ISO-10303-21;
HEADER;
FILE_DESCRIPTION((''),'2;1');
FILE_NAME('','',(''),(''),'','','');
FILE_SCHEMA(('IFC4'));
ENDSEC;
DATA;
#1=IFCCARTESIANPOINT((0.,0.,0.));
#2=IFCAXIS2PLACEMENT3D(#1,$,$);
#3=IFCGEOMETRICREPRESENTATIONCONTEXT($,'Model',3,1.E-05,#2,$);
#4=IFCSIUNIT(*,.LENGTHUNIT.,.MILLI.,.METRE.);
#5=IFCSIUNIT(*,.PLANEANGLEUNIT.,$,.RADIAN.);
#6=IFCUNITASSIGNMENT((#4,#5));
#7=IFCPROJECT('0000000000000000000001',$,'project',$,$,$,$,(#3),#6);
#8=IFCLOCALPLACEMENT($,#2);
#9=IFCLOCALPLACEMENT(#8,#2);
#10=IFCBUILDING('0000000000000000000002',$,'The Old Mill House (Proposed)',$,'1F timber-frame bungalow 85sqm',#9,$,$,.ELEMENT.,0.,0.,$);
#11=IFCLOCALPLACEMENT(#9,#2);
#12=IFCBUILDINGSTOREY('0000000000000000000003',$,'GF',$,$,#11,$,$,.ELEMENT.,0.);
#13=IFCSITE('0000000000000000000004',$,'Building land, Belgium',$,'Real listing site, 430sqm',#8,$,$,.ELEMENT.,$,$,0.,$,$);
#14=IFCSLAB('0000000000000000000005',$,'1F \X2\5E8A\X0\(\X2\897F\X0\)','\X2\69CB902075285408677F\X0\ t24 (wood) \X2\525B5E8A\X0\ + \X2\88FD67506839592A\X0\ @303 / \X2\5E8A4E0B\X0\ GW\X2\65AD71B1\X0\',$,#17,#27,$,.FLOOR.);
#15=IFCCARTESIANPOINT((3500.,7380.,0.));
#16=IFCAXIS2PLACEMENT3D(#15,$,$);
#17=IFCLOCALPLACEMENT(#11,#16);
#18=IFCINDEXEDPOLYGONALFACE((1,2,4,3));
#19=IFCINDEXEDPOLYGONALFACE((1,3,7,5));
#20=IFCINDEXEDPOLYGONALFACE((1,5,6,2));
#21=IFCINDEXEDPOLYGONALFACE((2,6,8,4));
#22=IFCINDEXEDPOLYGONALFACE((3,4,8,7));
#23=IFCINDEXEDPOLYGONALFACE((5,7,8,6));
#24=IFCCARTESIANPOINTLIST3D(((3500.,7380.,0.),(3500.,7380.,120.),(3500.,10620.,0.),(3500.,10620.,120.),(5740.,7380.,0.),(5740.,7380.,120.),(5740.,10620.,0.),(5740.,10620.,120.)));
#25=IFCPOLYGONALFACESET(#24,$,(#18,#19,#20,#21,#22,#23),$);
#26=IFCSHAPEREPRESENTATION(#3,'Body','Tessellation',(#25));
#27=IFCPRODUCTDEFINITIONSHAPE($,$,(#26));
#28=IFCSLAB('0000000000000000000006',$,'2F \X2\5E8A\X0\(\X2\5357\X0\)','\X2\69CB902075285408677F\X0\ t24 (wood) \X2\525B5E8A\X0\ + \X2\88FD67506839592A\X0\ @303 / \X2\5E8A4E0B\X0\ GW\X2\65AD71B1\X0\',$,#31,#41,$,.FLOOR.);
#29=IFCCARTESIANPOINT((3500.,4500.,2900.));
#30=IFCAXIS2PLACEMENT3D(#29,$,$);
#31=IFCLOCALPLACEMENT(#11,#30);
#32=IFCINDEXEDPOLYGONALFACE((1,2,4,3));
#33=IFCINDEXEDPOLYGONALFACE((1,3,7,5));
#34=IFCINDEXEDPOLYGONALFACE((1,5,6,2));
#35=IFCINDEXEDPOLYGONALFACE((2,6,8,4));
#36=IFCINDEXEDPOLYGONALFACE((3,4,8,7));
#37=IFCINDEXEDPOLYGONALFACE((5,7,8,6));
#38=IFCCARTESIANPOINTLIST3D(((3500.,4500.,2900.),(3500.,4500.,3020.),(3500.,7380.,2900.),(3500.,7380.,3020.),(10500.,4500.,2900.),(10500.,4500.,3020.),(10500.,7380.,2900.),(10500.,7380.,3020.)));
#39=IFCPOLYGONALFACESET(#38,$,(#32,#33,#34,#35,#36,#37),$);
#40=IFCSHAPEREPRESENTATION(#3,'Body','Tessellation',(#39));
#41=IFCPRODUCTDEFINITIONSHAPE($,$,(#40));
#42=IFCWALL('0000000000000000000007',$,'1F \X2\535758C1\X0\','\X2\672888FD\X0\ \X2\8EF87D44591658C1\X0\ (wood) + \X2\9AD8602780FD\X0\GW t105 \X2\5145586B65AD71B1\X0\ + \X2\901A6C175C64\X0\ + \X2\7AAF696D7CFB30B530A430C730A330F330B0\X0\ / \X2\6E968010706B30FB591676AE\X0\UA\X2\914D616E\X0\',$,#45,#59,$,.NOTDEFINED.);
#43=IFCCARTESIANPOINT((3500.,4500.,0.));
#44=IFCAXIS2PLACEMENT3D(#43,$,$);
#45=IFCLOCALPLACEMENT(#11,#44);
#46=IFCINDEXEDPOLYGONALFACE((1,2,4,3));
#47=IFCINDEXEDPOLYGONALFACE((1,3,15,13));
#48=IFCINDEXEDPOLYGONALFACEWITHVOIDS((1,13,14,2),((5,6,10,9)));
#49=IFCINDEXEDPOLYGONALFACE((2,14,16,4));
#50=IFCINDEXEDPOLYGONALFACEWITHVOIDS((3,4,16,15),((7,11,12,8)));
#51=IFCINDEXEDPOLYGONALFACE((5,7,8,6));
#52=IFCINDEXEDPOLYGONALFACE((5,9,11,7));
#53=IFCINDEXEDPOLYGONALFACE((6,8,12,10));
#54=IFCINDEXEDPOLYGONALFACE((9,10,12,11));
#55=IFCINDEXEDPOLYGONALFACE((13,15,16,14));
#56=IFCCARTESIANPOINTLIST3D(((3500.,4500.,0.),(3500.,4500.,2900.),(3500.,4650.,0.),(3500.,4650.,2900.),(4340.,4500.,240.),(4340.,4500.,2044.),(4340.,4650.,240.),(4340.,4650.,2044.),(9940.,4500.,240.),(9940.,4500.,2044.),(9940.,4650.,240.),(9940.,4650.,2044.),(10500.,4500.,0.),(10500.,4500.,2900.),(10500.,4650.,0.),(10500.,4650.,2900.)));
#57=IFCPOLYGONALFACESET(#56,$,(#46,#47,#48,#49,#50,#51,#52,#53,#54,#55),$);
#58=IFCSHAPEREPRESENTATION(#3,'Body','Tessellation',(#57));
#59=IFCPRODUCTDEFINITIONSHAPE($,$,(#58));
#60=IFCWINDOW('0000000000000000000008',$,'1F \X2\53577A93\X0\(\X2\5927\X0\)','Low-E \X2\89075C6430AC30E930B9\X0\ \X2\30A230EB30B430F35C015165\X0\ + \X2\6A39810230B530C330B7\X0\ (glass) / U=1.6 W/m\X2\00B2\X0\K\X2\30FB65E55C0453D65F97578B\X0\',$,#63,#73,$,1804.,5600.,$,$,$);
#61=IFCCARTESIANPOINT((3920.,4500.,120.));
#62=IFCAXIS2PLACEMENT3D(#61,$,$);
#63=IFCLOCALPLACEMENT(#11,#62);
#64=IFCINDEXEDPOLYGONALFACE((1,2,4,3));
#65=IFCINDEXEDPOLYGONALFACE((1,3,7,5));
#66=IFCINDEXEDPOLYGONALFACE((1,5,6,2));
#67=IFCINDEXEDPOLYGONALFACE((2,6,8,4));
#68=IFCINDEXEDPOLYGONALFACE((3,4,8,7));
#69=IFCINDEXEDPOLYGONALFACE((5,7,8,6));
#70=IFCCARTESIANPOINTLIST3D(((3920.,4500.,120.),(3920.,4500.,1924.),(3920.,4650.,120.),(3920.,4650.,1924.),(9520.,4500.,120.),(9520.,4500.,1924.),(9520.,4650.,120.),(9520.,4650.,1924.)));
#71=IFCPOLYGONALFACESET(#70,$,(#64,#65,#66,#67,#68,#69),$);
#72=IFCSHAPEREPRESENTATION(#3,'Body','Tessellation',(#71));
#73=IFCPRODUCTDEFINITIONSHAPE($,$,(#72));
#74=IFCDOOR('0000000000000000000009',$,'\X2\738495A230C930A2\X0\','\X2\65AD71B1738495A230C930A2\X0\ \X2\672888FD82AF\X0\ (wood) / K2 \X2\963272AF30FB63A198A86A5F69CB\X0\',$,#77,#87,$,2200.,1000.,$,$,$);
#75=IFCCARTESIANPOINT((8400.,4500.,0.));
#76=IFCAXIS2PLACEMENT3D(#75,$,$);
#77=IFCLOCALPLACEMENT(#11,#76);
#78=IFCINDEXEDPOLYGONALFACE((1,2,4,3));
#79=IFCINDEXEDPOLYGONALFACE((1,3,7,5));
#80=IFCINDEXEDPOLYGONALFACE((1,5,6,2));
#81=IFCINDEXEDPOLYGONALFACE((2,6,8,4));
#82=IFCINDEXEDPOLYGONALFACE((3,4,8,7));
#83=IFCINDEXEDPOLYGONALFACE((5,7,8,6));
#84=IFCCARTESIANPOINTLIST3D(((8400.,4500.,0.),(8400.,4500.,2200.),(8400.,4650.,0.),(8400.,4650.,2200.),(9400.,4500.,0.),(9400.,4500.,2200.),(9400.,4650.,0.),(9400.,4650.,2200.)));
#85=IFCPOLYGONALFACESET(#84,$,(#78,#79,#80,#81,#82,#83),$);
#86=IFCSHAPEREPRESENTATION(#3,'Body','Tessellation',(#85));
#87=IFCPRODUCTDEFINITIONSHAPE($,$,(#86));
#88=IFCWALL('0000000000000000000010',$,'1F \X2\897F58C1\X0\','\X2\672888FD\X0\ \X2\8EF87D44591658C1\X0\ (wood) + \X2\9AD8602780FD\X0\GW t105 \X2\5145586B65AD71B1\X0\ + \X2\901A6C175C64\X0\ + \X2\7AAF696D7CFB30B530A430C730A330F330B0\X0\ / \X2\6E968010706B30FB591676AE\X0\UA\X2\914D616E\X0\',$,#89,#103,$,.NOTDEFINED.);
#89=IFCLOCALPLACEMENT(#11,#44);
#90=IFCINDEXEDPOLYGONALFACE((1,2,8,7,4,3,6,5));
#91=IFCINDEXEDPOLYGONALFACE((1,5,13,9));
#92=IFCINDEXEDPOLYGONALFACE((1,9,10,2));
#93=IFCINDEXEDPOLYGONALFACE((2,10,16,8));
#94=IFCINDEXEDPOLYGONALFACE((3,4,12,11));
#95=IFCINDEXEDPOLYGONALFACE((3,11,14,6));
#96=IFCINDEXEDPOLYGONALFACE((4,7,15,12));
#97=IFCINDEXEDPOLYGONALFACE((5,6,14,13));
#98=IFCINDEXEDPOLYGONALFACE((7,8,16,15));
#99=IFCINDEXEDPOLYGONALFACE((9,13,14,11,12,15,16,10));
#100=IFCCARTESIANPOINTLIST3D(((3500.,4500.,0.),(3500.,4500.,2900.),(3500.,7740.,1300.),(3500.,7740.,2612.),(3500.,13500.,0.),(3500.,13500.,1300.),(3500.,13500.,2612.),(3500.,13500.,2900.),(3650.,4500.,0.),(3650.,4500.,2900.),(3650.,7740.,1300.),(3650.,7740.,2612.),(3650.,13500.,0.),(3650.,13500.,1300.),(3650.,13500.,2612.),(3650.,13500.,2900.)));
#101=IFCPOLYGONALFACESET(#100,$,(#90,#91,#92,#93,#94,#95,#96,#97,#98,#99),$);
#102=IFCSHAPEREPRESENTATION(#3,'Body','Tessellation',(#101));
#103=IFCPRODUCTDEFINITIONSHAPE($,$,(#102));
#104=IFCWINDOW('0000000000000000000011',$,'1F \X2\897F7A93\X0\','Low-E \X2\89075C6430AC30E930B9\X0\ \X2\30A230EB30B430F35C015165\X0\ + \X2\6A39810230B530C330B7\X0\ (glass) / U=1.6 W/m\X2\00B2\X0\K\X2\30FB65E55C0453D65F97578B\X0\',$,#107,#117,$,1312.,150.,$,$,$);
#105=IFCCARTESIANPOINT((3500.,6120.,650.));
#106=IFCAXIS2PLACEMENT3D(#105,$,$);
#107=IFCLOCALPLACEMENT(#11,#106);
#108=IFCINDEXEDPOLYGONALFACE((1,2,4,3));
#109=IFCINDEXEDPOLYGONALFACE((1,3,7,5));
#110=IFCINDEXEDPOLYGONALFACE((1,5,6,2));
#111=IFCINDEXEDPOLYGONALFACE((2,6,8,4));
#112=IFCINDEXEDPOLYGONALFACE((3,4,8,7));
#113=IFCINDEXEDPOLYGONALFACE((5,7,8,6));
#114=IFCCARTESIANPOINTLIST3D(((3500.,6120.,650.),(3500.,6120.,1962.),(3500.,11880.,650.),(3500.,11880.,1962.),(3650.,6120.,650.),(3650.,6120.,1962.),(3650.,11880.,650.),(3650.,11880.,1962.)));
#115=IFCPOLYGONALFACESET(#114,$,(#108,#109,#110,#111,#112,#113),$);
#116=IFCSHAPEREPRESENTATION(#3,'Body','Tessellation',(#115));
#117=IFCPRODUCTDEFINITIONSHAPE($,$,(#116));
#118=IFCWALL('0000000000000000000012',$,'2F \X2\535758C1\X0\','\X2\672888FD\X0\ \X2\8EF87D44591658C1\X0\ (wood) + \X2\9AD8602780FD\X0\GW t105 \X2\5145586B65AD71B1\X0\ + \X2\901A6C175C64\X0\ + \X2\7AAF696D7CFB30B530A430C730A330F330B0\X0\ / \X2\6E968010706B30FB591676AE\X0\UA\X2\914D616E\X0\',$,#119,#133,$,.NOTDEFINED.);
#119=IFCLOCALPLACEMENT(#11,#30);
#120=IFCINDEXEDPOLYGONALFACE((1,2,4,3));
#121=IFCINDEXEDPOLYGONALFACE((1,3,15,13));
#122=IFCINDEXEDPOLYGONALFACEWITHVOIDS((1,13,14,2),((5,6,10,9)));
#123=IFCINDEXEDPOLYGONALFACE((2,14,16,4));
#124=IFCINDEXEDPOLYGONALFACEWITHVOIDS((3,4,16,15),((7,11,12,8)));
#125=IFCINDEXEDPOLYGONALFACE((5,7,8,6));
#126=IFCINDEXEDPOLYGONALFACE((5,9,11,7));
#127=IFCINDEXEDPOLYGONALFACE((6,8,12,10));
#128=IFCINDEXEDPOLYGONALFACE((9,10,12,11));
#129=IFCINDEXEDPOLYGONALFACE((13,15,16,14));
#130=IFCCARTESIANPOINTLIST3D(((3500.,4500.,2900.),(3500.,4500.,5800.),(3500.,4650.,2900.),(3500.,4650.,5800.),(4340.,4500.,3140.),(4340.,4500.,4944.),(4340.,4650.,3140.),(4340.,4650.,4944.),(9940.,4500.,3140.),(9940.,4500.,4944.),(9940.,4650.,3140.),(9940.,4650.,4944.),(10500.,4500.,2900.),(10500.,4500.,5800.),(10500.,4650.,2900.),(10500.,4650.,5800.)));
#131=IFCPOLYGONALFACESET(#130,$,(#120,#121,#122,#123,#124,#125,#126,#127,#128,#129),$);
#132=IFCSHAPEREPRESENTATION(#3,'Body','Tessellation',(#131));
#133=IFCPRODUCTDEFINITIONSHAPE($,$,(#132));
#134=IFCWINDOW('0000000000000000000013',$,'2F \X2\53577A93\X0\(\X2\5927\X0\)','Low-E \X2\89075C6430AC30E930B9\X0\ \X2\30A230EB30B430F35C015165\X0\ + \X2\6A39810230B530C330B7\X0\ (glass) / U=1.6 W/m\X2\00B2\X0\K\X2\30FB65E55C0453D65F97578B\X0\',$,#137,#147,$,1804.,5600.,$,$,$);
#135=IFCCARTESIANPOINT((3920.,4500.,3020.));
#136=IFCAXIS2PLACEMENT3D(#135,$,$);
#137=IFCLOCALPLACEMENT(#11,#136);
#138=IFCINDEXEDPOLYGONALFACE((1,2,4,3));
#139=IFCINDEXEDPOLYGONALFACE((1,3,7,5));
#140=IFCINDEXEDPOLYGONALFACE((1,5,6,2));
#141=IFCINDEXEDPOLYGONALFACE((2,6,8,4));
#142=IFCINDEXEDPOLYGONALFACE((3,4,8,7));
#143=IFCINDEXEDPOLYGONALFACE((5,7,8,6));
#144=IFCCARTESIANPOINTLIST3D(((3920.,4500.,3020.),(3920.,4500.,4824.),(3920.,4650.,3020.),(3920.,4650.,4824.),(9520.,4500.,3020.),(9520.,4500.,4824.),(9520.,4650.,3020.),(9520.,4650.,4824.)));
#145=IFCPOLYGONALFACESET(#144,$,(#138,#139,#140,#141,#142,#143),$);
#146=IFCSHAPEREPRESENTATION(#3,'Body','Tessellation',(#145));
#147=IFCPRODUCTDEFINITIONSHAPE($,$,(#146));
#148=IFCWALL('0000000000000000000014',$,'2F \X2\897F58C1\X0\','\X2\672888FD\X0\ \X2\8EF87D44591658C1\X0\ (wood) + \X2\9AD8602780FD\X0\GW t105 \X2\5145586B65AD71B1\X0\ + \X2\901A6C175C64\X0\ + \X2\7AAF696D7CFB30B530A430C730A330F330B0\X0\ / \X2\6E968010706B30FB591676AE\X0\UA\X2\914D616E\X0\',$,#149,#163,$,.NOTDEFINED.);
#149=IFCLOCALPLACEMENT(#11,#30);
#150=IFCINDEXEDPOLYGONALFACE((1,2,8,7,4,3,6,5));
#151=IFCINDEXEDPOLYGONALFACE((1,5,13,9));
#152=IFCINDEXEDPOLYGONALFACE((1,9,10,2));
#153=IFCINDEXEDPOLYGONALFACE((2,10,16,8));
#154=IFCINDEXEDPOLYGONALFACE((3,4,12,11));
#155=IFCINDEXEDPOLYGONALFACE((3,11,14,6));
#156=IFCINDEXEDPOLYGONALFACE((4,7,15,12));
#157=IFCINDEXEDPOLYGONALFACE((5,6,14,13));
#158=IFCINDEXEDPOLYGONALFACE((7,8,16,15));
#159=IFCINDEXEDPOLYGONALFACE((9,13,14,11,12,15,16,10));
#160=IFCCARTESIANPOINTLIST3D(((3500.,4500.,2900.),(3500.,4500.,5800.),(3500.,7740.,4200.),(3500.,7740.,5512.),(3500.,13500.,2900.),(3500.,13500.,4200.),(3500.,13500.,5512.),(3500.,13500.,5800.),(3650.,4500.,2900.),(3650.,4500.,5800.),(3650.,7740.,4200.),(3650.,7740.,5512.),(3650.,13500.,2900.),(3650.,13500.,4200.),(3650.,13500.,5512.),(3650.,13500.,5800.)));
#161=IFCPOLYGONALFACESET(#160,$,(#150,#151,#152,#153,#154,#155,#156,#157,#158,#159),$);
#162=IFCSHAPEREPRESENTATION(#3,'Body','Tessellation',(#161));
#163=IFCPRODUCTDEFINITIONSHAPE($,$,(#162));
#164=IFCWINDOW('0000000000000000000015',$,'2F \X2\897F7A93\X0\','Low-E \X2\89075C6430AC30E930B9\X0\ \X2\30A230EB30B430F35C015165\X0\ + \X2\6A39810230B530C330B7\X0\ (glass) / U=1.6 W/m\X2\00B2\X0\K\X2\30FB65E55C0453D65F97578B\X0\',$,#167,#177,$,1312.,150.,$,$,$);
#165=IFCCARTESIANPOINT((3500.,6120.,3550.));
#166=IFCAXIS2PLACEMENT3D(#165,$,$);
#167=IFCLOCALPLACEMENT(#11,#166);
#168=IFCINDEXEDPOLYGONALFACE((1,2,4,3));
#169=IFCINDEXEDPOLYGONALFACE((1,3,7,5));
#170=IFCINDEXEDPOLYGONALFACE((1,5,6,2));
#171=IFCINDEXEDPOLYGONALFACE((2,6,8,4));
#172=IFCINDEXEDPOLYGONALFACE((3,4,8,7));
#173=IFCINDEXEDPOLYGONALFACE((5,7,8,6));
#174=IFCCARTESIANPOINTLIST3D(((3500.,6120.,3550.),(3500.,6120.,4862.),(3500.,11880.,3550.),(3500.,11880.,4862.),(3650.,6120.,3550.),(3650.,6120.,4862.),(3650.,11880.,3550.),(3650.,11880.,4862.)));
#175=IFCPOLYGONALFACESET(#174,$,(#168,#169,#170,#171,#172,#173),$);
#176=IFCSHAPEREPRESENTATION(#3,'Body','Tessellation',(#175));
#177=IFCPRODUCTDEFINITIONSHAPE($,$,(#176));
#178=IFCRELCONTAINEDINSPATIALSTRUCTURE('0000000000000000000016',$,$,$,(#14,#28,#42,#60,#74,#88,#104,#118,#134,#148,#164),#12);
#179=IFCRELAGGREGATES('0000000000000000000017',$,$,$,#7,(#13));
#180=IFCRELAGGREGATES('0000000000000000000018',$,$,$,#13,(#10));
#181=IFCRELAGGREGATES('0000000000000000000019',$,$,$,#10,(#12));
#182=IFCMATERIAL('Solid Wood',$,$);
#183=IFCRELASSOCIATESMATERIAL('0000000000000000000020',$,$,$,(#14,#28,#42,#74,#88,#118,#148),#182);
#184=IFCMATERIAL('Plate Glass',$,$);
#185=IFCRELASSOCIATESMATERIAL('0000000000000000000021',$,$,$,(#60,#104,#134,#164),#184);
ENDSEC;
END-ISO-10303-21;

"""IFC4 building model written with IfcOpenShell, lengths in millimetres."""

from ifc_helpers import new_model, si_unit, frame, frame_2d, origin, place, context, project, spatial, rectangle, extrude, material, element, fill, save


model = new_model("IFC4")

# Units and contexts
model_context = context("Model", 3, precision=1e-05, world=origin())
ifc_project = project(units=[si_unit("LENGTHUNIT", "METRE", prefix="MILLI"), si_unit("PLANEANGLEUNIT", "RADIAN")], contexts=[model_context])

# Site, building, storey
site_placement = place(None, origin())
site = spatial("IfcSite", under=ifc_project, at=site_placement, Name="Building land, Belgium", ObjectType="Real listing site, 430sqm", CompositionType="ELEMENT", RefElevation=0.0)
building_placement = place(site_placement, origin())
building = spatial("IfcBuilding", under=site, at=building_placement, Name="The Old Mill House (Proposed)", ObjectType="1F timber-frame bungalow 85sqm", CompositionType="ELEMENT", ElevationOfRefHeight=0.0, ElevationOfTerrain=0.0)
storey_placement = place(building_placement, origin())
storey = spatial("IfcBuildingStorey", under=building, at=storey_placement, Name="GF", CompositionType="ELEMENT", Elevation=0.0)

# Slabs
ifc_material_1 = material(Name="Solid Wood")
slab_1_placement = place(storey_placement, frame((3500.0, 7380.0, 0.0)))
element("IfcSlab", 1, at=slab_1_placement, inside=storey, material=ifc_material_1, Name="1F 床(西)", Description="構造用合板 t24 (wood) 剛床 + 製材根太 @303 / 床下 GW断熱", PredefinedType="FLOOR", context=model_context, shape_type="SweptSolid", body=[
    extrude(rectangle(XDim=2240.0, YDim=3240.0, at=frame_2d((1120.0, 1620.0))), frame((3500.0, 7380.0, 0.0)), (0.0, 0.0, 1.0), 120.0),
])
slab_2_placement = place(storey_placement, frame((3500.0, 4500.0, 2900.0)))
element("IfcSlab", 2, at=slab_2_placement, inside=storey, material=ifc_material_1, Name="2F 床(南)", Description="構造用合板 t24 (wood) 剛床 + 製材根太 @303 / 床下 GW断熱", PredefinedType="FLOOR", context=model_context, shape_type="SweptSolid", body=[
    extrude(rectangle(XDim=7000.0, YDim=2880.0, at=frame_2d((3500.0, 1440.0))), frame((3500.0, 4500.0, 2900.0)), (0.0, 0.0, 1.0), 120.0),
])

# Wall, openings, window, door
wall_1_placement = place(storey_placement, frame((3500.0, 4500.0, 0.0)))
wall_1 = element("IfcWall", 3, at=wall_1_placement, inside=storey, material=ifc_material_1, Name="1F 南壁", Description="木製 軸組外壁 (wood) + 高性能GW t105 充填断熱 + 通気層 + 窯業系サイディング / 準耐火・外皮UA配慮", PredefinedType="NOTDEFINED", context=model_context, shape_type="SweptSolid", body=[
    extrude(rectangle(XDim=7000.0, YDim=150.0, at=frame_2d((3500.0, 75.0))), frame((3500.0, 4500.0, 0.0)), (0.0, 0.0, 1.0), 2900.0),
])
opening_1_placement = place(storey_placement, frame((3920.0, 4500.0, 120.0)))
opening_1 = element("IfcOpeningElement", 4, at=opening_1_placement, cuts=wall_1, PredefinedType="NOTDEFINED", context=model_context, shape_type="SweptSolid", body=[
    extrude(rectangle(XDim=5600.0, YDim=150.0, at=frame_2d((2800.0, 75.0))), frame((3920.0, 4500.0, 120.0)), (0.0, 0.0, 1.0), 1804.0),
])
opening_2_placement = place(storey_placement, frame((8400.0, 4500.0, 0.0)))
opening_2 = element("IfcOpeningElement", 5, at=opening_2_placement, cuts=wall_1, PredefinedType="NOTDEFINED", context=model_context, shape_type="SweptSolid", body=[
    extrude(rectangle(XDim=1000.0, YDim=150.0, at=frame_2d((500.0, 75.0))), frame((8400.0, 4500.0, 0.0)), (0.0, 0.0, 1.0), 2200.0),
])
ifc_material_2 = material(Name="Plate Glass")
window_1_placement = place(storey_placement, frame((3920.0, 4500.0, 120.0)))
window_1 = element("IfcWindow", 6, at=window_1_placement, inside=storey, material=ifc_material_2, Name="1F 南窓(大)", Description="Low-E 複層ガラス アルゴン封入 + 樹脂サッシ (glass) / U=1.6 W/m²K・日射取得型", OverallHeight=1804.0, OverallWidth=5600.0, context=model_context, shape_type="SweptSolid", body=[
    extrude(rectangle(XDim=5600.0, YDim=150.0, at=frame_2d((2800.0, 75.0))), frame((3920.0, 4500.0, 120.0)), (0.0, 0.0, 1.0), 1804.0),
])
fill(opening_1, window_1)
door_placement = place(storey_placement, frame((8400.0, 4500.0, 0.0)))
door = element("IfcDoor", 7, at=door_placement, inside=storey, material=ifc_material_1, Name="玄関ドア", Description="断熱玄関ドア 木製芯 (wood) / K2 防犯・採風機構", OverallHeight=2200.0, OverallWidth=1000.0, context=model_context, shape_type="SweptSolid", body=[
    extrude(rectangle(XDim=1000.0, YDim=150.0, at=frame_2d((500.0, 75.0))), frame((8400.0, 4500.0, 0.0)), (0.0, 0.0, 1.0), 2200.0),
])
fill(opening_2, door)

# Walls, openings, windows
wall_2_placement = place(storey_placement, frame((3500.0, 4500.0, 0.0)))
wall_2 = element("IfcWall", 8, at=wall_2_placement, inside=storey, material=ifc_material_1, Name="1F 西壁", Description="木製 軸組外壁 (wood) + 高性能GW t105 充填断熱 + 通気層 + 窯業系サイディング / 準耐火・外皮UA配慮", PredefinedType="NOTDEFINED", context=model_context, shape_type="SweptSolid", body=[
    extrude(rectangle(XDim=150.0, YDim=9000.0, at=frame_2d((75.0, 4500.0))), frame((3500.0, 4500.0, 0.0)), (0.0, 0.0, 1.0), 2900.0),
])
opening_3_placement = place(storey_placement, frame((3500.0, 6120.0, 650.0)))
opening_3 = element("IfcOpeningElement", 9, at=opening_3_placement, cuts=wall_2, PredefinedType="NOTDEFINED", context=model_context, shape_type="SweptSolid", body=[
    extrude(rectangle(XDim=150.0, YDim=5760.0, at=frame_2d((75.0, 2880.0))), frame((3500.0, 6120.0, 650.0)), (0.0, 0.0, 1.0), 1312.0),
])
window_2_placement = place(storey_placement, frame((3500.0, 6120.0, 650.0)))
window_2 = element("IfcWindow", 10, at=window_2_placement, inside=storey, material=ifc_material_2, Name="1F 西窓", Description="Low-E 複層ガラス アルゴン封入 + 樹脂サッシ (glass) / U=1.6 W/m²K・日射取得型", OverallHeight=1312.0, OverallWidth=150.0, context=model_context, shape_type="SweptSolid", body=[
    extrude(rectangle(XDim=150.0, YDim=5760.0, at=frame_2d((75.0, 2880.0))), frame((3500.0, 6120.0, 650.0)), (0.0, 0.0, 1.0), 1312.0),
])
fill(opening_3, window_2)
wall_3_placement = place(storey_placement, frame((3500.0, 4500.0, 2900.0)))
wall_3 = element("IfcWall", 11, at=wall_3_placement, inside=storey, material=ifc_material_1, Name="2F 南壁", Description="木製 軸組外壁 (wood) + 高性能GW t105 充填断熱 + 通気層 + 窯業系サイディング / 準耐火・外皮UA配慮", PredefinedType="NOTDEFINED", context=model_context, shape_type="SweptSolid", body=[
    extrude(rectangle(XDim=7000.0, YDim=150.0, at=frame_2d((3500.0, 75.0))), frame((3500.0, 4500.0, 2900.0)), (0.0, 0.0, 1.0), 2900.0),
])
opening_4_placement = place(storey_placement, frame((3920.0, 4500.0, 3020.0)))
opening_4 = element("IfcOpeningElement", 12, at=opening_4_placement, cuts=wall_3, PredefinedType="NOTDEFINED", context=model_context, shape_type="SweptSolid", body=[
    extrude(rectangle(XDim=5600.0, YDim=150.0, at=frame_2d((2800.0, 75.0))), frame((3920.0, 4500.0, 3020.0)), (0.0, 0.0, 1.0), 1804.0),
])
window_3_placement = place(storey_placement, frame((3920.0, 4500.0, 3020.0)))
window_3 = element("IfcWindow", 13, at=window_3_placement, inside=storey, material=ifc_material_2, Name="2F 南窓(大)", Description="Low-E 複層ガラス アルゴン封入 + 樹脂サッシ (glass) / U=1.6 W/m²K・日射取得型", OverallHeight=1804.0, OverallWidth=5600.0, context=model_context, shape_type="SweptSolid", body=[
    extrude(rectangle(XDim=5600.0, YDim=150.0, at=frame_2d((2800.0, 75.0))), frame((3920.0, 4500.0, 3020.0)), (0.0, 0.0, 1.0), 1804.0),
])
fill(opening_4, window_3)
wall_4_placement = place(storey_placement, frame((3500.0, 4500.0, 2900.0)))
wall_4 = element("IfcWall", 14, at=wall_4_placement, inside=storey, material=ifc_material_1, Name="2F 西壁", Description="木製 軸組外壁 (wood) + 高性能GW t105 充填断熱 + 通気層 + 窯業系サイディング / 準耐火・外皮UA配慮", PredefinedType="NOTDEFINED", context=model_context, shape_type="SweptSolid", body=[
    extrude(rectangle(XDim=150.0, YDim=9000.0, at=frame_2d((75.0, 4500.0))), frame((3500.0, 4500.0, 2900.0)), (0.0, 0.0, 1.0), 2900.0),
])
opening_5_placement = place(storey_placement, frame((3500.0, 6120.0, 3550.0)))
opening_5 = element("IfcOpeningElement", 15, at=opening_5_placement, cuts=wall_4, PredefinedType="NOTDEFINED", context=model_context, shape_type="SweptSolid", body=[
    extrude(rectangle(XDim=150.0, YDim=5760.0, at=frame_2d((75.0, 2880.0))), frame((3500.0, 6120.0, 3550.0)), (0.0, 0.0, 1.0), 1312.0),
])
window_4_placement = place(storey_placement, frame((3500.0, 6120.0, 3550.0)))
window_4 = element("IfcWindow", 16, at=window_4_placement, inside=storey, material=ifc_material_2, Name="2F 西窓", Description="Low-E 複層ガラス アルゴン封入 + 樹脂サッシ (glass) / U=1.6 W/m²K・日射取得型", OverallHeight=1312.0, OverallWidth=150.0, context=model_context, shape_type="SweptSolid", body=[
    extrude(rectangle(XDim=150.0, YDim=5760.0, at=frame_2d((75.0, 2880.0))), frame((3500.0, 6120.0, 3550.0)), (0.0, 0.0, 1.0), 1312.0),
])
fill(opening_5, window_4)

save(model, "model.ifc")
